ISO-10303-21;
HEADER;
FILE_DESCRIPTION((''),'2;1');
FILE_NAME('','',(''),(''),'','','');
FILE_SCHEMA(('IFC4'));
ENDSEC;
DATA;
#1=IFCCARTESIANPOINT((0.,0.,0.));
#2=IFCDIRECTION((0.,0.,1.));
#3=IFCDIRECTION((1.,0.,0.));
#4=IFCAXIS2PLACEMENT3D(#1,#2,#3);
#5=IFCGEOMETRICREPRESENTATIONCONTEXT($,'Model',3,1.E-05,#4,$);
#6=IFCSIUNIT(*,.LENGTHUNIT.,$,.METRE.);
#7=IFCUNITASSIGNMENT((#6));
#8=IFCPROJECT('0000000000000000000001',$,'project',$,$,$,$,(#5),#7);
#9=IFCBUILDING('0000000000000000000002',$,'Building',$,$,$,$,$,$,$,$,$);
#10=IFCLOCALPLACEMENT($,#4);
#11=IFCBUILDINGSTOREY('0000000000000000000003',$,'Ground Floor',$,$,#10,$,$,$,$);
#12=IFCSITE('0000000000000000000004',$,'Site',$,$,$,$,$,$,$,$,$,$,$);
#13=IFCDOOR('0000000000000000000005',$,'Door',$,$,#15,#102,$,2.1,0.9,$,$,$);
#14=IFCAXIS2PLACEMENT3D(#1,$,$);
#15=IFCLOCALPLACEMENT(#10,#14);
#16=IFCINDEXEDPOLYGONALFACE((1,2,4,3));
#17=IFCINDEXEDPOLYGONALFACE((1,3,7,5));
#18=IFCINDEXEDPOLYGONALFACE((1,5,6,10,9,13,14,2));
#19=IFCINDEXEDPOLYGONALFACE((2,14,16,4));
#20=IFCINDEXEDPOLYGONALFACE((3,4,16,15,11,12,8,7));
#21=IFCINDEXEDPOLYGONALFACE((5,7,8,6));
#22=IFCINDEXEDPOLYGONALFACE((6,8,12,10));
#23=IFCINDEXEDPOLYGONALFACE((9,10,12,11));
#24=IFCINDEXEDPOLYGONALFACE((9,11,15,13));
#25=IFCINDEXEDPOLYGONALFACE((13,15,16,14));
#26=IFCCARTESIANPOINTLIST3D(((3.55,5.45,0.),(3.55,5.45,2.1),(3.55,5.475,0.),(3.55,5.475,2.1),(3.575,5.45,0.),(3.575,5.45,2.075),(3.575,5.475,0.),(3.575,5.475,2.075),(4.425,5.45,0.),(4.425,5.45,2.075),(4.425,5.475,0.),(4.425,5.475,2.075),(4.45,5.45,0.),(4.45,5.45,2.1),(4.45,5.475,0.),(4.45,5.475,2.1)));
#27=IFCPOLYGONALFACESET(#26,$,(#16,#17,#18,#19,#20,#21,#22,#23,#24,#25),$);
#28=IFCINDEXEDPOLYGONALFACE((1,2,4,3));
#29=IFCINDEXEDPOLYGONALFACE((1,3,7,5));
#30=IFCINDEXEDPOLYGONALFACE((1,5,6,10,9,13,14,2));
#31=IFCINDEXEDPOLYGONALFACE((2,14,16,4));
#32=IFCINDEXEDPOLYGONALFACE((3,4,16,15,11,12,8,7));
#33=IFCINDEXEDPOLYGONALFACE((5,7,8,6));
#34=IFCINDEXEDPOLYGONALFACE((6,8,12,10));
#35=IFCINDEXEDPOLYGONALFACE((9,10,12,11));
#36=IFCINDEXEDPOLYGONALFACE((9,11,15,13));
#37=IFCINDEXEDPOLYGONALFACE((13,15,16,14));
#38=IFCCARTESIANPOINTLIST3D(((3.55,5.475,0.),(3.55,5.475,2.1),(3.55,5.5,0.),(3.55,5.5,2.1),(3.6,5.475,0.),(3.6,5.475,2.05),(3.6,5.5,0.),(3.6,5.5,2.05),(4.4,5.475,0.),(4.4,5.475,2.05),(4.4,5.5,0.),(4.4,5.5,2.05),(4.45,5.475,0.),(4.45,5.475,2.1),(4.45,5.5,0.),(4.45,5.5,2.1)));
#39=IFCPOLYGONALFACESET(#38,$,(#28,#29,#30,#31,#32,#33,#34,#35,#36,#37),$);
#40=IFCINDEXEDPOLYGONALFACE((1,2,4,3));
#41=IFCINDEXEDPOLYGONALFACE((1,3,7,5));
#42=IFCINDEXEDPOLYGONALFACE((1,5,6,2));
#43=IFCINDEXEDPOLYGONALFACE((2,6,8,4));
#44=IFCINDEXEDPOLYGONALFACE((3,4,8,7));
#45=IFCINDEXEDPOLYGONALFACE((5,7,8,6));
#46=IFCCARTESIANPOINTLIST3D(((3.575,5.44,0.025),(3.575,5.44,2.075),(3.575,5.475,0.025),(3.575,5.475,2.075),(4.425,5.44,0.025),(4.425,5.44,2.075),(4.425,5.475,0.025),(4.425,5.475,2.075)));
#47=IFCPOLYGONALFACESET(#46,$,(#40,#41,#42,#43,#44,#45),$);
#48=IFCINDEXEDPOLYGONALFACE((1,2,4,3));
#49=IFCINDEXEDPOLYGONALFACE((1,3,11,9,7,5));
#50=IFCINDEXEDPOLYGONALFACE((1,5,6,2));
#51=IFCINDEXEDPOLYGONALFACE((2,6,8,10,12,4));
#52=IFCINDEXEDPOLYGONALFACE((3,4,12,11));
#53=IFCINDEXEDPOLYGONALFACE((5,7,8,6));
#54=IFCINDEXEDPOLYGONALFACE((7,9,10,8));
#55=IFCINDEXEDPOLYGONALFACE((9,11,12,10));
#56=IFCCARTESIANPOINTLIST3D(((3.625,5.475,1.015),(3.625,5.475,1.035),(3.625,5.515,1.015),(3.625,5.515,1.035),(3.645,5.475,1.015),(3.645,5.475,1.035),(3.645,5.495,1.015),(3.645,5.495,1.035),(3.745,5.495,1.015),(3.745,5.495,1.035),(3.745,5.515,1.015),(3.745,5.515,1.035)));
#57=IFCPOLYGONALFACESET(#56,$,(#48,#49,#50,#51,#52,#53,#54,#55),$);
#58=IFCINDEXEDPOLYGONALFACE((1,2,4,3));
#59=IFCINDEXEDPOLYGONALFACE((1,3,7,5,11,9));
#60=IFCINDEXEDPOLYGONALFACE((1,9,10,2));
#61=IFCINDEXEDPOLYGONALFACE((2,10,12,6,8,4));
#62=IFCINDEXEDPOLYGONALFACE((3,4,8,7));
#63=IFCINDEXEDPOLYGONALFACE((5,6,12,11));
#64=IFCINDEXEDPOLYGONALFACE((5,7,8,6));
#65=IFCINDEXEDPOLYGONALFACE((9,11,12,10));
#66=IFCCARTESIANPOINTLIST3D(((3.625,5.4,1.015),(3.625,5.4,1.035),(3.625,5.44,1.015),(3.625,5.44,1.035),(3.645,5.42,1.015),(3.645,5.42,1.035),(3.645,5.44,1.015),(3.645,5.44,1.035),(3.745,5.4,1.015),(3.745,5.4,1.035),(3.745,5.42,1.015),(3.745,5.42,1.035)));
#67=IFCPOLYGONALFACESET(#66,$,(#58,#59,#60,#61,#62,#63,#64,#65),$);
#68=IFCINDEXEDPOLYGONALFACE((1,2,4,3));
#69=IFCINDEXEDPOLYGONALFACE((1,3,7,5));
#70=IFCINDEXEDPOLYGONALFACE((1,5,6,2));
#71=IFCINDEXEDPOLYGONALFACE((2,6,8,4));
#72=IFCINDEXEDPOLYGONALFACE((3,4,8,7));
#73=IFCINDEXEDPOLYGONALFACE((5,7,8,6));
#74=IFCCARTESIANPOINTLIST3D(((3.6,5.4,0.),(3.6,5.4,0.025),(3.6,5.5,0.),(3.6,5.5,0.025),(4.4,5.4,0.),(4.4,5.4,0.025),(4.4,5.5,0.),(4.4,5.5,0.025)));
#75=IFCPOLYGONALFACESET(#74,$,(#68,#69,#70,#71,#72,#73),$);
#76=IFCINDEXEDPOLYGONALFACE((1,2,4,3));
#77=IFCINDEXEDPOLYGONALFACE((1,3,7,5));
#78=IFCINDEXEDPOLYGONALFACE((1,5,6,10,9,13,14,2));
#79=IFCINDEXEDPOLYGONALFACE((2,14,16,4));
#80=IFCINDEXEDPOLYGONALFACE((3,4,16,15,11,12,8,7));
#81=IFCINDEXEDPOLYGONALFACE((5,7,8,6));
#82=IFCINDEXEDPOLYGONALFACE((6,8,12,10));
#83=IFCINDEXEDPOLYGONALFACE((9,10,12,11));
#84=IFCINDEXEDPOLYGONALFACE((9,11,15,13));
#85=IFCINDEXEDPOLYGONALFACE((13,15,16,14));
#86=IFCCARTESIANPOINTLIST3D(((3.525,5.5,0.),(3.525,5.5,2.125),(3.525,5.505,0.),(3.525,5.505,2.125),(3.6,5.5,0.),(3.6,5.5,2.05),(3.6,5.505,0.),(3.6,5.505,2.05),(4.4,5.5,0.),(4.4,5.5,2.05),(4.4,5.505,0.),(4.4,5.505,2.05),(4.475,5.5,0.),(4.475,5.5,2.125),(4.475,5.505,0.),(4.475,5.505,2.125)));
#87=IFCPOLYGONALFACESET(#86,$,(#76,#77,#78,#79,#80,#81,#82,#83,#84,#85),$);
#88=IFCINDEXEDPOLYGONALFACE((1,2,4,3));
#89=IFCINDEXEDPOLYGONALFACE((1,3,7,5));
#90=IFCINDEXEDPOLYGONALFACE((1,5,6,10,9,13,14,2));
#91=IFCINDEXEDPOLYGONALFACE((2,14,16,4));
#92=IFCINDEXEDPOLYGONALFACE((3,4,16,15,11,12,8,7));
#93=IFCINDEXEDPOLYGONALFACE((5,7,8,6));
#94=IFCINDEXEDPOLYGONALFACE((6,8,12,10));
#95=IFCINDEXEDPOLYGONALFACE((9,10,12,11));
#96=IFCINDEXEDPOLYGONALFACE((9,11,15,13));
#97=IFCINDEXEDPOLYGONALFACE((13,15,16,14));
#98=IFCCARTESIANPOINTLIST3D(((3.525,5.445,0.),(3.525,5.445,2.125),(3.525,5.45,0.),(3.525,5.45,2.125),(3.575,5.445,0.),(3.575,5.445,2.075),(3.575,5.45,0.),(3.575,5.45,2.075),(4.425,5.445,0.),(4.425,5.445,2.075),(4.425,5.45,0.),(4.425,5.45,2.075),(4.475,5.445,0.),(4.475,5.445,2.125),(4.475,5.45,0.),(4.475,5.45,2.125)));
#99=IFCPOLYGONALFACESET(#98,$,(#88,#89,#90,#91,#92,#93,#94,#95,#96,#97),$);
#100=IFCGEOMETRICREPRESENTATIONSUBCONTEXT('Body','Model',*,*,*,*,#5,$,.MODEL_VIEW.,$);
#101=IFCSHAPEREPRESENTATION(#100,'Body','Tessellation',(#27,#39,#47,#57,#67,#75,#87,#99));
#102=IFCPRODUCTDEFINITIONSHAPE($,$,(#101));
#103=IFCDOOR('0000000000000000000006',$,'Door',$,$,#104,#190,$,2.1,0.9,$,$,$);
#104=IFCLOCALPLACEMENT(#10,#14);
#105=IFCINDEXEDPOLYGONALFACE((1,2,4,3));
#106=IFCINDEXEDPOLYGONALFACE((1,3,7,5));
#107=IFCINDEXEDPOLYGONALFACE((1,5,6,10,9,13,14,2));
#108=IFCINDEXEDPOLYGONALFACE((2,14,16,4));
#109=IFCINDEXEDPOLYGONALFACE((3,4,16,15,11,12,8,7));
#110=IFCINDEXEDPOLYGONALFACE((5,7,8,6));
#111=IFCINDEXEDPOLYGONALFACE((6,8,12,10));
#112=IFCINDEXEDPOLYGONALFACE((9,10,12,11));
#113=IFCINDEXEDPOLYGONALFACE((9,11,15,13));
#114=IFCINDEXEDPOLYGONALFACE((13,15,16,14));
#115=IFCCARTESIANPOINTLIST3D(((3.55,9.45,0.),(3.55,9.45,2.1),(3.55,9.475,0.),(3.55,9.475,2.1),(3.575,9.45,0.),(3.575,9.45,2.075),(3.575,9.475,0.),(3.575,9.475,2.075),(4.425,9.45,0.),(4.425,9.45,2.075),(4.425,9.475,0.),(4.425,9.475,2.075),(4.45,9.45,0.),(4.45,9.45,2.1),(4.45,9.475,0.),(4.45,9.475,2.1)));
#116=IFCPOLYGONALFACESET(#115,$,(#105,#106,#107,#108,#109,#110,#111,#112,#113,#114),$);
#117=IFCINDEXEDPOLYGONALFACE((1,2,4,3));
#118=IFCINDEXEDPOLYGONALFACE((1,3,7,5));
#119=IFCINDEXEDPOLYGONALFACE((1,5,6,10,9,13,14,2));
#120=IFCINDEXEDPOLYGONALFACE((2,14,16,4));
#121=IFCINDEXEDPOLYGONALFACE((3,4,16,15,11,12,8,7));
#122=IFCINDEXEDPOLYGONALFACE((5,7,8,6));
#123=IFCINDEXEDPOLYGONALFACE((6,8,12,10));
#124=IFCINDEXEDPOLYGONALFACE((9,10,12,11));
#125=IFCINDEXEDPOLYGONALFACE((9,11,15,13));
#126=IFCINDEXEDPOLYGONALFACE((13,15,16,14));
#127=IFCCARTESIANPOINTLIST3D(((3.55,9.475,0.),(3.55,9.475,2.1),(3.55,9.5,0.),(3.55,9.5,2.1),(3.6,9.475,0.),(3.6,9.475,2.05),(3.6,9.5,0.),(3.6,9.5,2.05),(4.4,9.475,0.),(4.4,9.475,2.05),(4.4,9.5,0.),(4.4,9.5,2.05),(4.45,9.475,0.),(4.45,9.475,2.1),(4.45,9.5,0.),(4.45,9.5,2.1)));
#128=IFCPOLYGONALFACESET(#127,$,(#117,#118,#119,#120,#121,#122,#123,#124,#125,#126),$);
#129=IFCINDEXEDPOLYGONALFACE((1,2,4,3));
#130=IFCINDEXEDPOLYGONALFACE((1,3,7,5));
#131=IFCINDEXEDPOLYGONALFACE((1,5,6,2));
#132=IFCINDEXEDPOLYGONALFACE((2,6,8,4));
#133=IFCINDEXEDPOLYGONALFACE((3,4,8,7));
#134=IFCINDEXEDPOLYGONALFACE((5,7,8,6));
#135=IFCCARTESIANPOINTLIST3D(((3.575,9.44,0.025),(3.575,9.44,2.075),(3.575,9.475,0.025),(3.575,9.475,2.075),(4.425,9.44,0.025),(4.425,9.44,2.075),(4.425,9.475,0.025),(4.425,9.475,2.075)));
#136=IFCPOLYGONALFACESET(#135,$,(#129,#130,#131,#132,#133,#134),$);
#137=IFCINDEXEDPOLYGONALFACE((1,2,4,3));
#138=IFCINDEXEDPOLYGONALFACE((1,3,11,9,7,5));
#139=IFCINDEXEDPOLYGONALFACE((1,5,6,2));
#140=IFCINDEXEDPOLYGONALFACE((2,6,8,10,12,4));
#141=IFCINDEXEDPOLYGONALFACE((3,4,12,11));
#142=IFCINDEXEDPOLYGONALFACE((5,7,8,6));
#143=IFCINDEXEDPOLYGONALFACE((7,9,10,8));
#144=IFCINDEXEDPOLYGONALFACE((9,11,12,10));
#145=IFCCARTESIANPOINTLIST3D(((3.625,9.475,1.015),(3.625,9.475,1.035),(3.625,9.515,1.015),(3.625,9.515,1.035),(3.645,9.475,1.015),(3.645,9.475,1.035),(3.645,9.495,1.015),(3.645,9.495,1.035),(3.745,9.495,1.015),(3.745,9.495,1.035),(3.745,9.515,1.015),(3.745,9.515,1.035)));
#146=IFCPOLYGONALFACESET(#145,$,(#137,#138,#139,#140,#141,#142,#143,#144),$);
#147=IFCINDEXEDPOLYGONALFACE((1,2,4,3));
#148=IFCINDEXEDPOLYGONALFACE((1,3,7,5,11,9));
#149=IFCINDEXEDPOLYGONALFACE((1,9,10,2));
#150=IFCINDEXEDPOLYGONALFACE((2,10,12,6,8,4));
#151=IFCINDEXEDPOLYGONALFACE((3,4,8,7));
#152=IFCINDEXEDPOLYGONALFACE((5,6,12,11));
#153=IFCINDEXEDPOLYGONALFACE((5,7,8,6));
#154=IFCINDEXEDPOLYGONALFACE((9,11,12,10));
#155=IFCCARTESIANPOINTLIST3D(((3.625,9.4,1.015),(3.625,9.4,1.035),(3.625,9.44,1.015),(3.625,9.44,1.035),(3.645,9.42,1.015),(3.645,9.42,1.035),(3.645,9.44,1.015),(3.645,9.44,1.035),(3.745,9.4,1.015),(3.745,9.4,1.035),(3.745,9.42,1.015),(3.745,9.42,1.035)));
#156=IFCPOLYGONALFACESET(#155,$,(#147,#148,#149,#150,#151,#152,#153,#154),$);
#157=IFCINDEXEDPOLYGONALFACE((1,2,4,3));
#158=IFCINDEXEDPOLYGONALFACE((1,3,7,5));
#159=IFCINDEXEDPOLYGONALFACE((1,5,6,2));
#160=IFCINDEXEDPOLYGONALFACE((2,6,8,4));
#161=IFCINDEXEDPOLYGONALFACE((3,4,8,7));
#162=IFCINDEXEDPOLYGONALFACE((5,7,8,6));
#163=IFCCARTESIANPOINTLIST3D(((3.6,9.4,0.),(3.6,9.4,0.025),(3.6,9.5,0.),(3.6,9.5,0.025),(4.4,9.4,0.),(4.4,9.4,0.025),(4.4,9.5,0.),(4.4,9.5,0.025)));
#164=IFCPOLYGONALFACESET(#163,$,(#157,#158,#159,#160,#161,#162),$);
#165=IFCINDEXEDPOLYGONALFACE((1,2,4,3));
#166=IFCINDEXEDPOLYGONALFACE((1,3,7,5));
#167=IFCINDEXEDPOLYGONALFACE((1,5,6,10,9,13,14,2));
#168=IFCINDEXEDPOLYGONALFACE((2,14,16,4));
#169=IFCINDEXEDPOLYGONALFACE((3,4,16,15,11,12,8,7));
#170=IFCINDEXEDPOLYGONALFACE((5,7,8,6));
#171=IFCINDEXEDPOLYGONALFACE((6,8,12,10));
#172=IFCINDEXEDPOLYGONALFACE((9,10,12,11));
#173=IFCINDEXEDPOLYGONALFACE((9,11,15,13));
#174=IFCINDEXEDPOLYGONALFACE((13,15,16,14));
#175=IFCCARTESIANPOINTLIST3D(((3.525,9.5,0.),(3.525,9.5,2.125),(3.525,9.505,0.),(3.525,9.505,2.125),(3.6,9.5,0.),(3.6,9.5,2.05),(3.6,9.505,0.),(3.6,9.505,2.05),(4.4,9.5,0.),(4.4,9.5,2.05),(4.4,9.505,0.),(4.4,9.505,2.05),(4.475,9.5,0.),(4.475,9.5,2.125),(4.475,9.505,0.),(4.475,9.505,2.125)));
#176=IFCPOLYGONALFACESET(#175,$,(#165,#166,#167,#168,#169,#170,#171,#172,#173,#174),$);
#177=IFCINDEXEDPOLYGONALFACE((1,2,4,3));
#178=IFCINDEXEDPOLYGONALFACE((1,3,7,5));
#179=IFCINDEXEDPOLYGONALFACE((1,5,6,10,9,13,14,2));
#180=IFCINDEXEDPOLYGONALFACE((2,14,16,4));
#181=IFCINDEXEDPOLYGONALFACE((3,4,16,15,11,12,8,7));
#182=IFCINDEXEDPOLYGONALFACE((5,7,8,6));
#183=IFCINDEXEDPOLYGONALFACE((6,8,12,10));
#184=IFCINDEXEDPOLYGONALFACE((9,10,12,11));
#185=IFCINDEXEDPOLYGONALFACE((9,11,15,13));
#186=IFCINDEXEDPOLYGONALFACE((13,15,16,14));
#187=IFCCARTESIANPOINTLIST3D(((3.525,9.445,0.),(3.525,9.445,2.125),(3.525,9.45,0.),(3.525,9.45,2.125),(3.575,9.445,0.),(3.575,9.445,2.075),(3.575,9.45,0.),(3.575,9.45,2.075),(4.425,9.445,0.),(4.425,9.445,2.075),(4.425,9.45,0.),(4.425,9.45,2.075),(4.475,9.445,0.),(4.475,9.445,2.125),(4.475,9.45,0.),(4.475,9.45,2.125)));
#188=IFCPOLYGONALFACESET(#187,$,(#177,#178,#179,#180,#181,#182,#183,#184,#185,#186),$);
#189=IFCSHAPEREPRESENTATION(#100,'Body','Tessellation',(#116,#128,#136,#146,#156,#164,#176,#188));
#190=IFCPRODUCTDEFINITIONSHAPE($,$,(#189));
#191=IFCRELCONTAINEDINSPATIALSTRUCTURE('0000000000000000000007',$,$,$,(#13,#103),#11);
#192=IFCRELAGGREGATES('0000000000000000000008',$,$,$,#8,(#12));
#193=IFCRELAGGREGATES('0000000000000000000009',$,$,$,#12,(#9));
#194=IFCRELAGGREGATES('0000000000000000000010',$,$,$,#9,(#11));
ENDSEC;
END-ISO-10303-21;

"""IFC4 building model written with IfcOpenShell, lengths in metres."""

from ifc_helpers import new_model, si_unit, frame, origin_with_axes, place, context, subcontext, project, spatial, line, indexed_curve, outline, extrude, element, save


model = new_model("IFC4")

# Units and contexts
model_context = context("Model", 3, precision=1e-05, world=origin_with_axes())
body_context = subcontext(model_context, "Body", "Model", "MODEL_VIEW")
ifc_project = project(units=[si_unit("LENGTHUNIT", "METRE")], contexts=[model_context])

# Site, building, storey
site = spatial("IfcSite", under=ifc_project, Name="Site")
building = spatial("IfcBuilding", under=site, Name="Building")
storey_placement = place(None, origin_with_axes())
storey = spatial("IfcBuildingStorey", under=building, at=storey_placement, Name="Ground Floor")

# Doors
door_1_placement = place(storey_placement, frame((4.45, 5.5, 0.0), z_axis=(0.0, 0.0, 1.0), x_axis=(-1.0, 0.0, 0.0)))
element("IfcDoor", 1, at=door_1_placement, inside=storey, Name="Door", OverallHeight=2.1, OverallWidth=0.9, context=body_context, shape_type="SweptSolid", body=[
    extrude(outline(indexed_curve([(0.0, 0.0), (0.0, 2.1), (0.9, 2.1), (0.9, 0.0), (0.875, 0.0), (0.875, 2.075), (0.025, 2.075), (0.025, 0.0)], segments=[line(1, 2, 3, 4, 5, 6, 7, 8, 1)])), frame((0.0, 0.025, 0.0), z_axis=(0.0, -1.0, 0.0), x_axis=(1.0, 0.0, 0.0)), (0.0, 0.0, -1.0), 0.025),
    extrude(outline(indexed_curve([(0.0, 0.0), (0.0, 2.1), (0.9, 2.1), (0.9, 0.0), (0.85, 0.0), (0.85, 2.05), (0.05, 2.05), (0.05, 0.0)], segments=[line(1, 2, 3, 4, 5, 6, 7, 8, 1)])), frame((0.0, 0.0, 0.0), z_axis=(0.0, -1.0, 0.0), x_axis=(1.0, 0.0, 0.0)), (0.0, 0.0, -1.0), 0.025),
    extrude(outline(indexed_curve([(0.0, 0.0), (0.85, 0.0), (0.85, 0.035), (0.0, 0.035)], segments=[line(1, 2, 3, 4, 1)])), frame((0.025, 0.025, 0.025), z_axis=(0.0, 0.0, 1.0), x_axis=(1.0, 0.0, 0.0)), (0.0, 0.0, 1.0), 2.05),
    extrude(outline(indexed_curve([(0.0, 0.0), (0.0, -0.04), (-0.12, -0.04), (-0.12, -0.02), (-0.02, -0.02), (-0.02, 0.0)], segments=[line(1, 2, 3, 4, 5, 6, 1)])), frame((0.825, 0.025, 1.015), z_axis=(0.0, 0.0, 1.0), x_axis=(1.0, 0.0, 0.0)), (0.0, 0.0, 1.0), 0.02),
    extrude(outline(indexed_curve([(0.0, 0.0), (0.0, 0.04), (-0.12, 0.04), (-0.12, 0.02), (-0.02, 0.02), (-0.02, 0.0)], segments=[line(1, 2, 3, 4, 5, 6, 1)])), frame((0.825, 0.06, 1.015), z_axis=(0.0, 0.0, 1.0), x_axis=(1.0, 0.0, 0.0)), (0.0, 0.0, 1.0), 0.02),
    extrude(outline(indexed_curve([(0.0, 0.0), (0.8, 0.0), (0.8, 0.1), (0.0, 0.1)], segments=[line(1, 2, 3, 4, 1)])), frame((0.05, 0.0, 0.0), z_axis=(0.0, 0.0, 1.0), x_axis=(1.0, 0.0, 0.0)), (0.0, 0.0, 1.0), 0.025),
    extrude(outline(indexed_curve([(0.0, 0.0), (0.0, 2.125), (0.95, 2.125), (0.95, 0.0), (0.875, 0.0), (0.875, 2.05), (0.075, 2.05), (0.075, 0.0)], segments=[line(1, 2, 3, 4, 5, 6, 7, 8, 1)])), frame((-0.025, -0.005, 0.0), z_axis=(0.0, -1.0, 0.0), x_axis=(1.0, 0.0, 0.0)), (0.0, 0.0, -1.0), 0.005),
    extrude(outline(indexed_curve([(0.0, 0.0), (0.0, 2.125), (0.95, 2.125), (0.95, 0.0), (0.9, 0.0), (0.9, 2.075), (0.05, 2.075), (0.05, 0.0)], segments=[line(1, 2, 3, 4, 5, 6, 7, 8, 1)])), frame((-0.025, 0.05, 0.0), z_axis=(0.0, -1.0, 0.0), x_axis=(1.0, 0.0, 0.0)), (0.0, 0.0, -1.0), 0.005),
])
door_2_placement = place(storey_placement, frame((4.45, 9.5, 0.0), z_axis=(0.0, 0.0, 1.0), x_axis=(-1.0, 0.0, 0.0)))
element("IfcDoor", 2, at=door_2_placement, inside=storey, Name="Door", OverallHeight=2.1, OverallWidth=0.9, context=body_context, shape_type="SweptSolid", body=[
    extrude(outline(indexed_curve([(0.0, 0.0), (0.0, 2.1), (0.9, 2.1), (0.9, 0.0), (0.875, 0.0), (0.875, 2.075), (0.025, 2.075), (0.025, 0.0)], segments=[line(1, 2, 3, 4, 5, 6, 7, 8, 1)])), frame((0.0, 0.025, 0.0), z_axis=(0.0, -1.0, 0.0), x_axis=(1.0, 0.0, 0.0)), (0.0, 0.0, -1.0), 0.025),
    extrude(outline(indexed_curve([(0.0, 0.0), (0.0, 2.1), (0.9, 2.1), (0.9, 0.0), (0.85, 0.0), (0.85, 2.05), (0.05, 2.05), (0.05, 0.0)], segments=[line(1, 2, 3, 4, 5, 6, 7, 8, 1)])), frame((0.0, 0.0, 0.0), z_axis=(0.0, -1.0, 0.0), x_axis=(1.0, 0.0, 0.0)), (0.0, 0.0, -1.0), 0.025),
    extrude(outline(indexed_curve([(0.0, 0.0), (0.85, 0.0), (0.85, 0.035), (0.0, 0.035)], segments=[line(1, 2, 3, 4, 1)])), frame((0.025, 0.025, 0.025), z_axis=(0.0, 0.0, 1.0), x_axis=(1.0, 0.0, 0.0)), (0.0, 0.0, 1.0), 2.05),
    extrude(outline(indexed_curve([(0.0, 0.0), (0.0, -0.04), (-0.12, -0.04), (-0.12, -0.02), (-0.02, -0.02), (-0.02, 0.0)], segments=[line(1, 2, 3, 4, 5, 6, 1)])), frame((0.825, 0.025, 1.015), z_axis=(0.0, 0.0, 1.0), x_axis=(1.0, 0.0, 0.0)), (0.0, 0.0, 1.0), 0.02),
    extrude(outline(indexed_curve([(0.0, 0.0), (0.0, 0.04), (-0.12, 0.04), (-0.12, 0.02), (-0.02, 0.02), (-0.02, 0.0)], segments=[line(1, 2, 3, 4, 5, 6, 1)])), frame((0.825, 0.06, 1.015), z_axis=(0.0, 0.0, 1.0), x_axis=(1.0, 0.0, 0.0)), (0.0, 0.0, 1.0), 0.02),
    extrude(outline(indexed_curve([(0.0, 0.0), (0.8, 0.0), (0.8, 0.1), (0.0, 0.1)], segments=[line(1, 2, 3, 4, 1)])), frame((0.05, 0.0, 0.0), z_axis=(0.0, 0.0, 1.0), x_axis=(1.0, 0.0, 0.0)), (0.0, 0.0, 1.0), 0.025),
    extrude(outline(indexed_curve([(0.0, 0.0), (0.0, 2.125), (0.95, 2.125), (0.95, 0.0), (0.875, 0.0), (0.875, 2.05), (0.075, 2.05), (0.075, 0.0)], segments=[line(1, 2, 3, 4, 5, 6, 7, 8, 1)])), frame((-0.025, -0.005, 0.0), z_axis=(0.0, -1.0, 0.0), x_axis=(1.0, 0.0, 0.0)), (0.0, 0.0, -1.0), 0.005),
    extrude(outline(indexed_curve([(0.0, 0.0), (0.0, 2.125), (0.95, 2.125), (0.95, 0.0), (0.9, 0.0), (0.9, 2.075), (0.05, 2.075), (0.05, 0.0)], segments=[line(1, 2, 3, 4, 5, 6, 7, 8, 1)])), frame((-0.025, 0.05, 0.0), z_axis=(0.0, -1.0, 0.0), x_axis=(1.0, 0.0, 0.0)), (0.0, 0.0, -1.0), 0.005),
])

save(model, "model.ifc")
